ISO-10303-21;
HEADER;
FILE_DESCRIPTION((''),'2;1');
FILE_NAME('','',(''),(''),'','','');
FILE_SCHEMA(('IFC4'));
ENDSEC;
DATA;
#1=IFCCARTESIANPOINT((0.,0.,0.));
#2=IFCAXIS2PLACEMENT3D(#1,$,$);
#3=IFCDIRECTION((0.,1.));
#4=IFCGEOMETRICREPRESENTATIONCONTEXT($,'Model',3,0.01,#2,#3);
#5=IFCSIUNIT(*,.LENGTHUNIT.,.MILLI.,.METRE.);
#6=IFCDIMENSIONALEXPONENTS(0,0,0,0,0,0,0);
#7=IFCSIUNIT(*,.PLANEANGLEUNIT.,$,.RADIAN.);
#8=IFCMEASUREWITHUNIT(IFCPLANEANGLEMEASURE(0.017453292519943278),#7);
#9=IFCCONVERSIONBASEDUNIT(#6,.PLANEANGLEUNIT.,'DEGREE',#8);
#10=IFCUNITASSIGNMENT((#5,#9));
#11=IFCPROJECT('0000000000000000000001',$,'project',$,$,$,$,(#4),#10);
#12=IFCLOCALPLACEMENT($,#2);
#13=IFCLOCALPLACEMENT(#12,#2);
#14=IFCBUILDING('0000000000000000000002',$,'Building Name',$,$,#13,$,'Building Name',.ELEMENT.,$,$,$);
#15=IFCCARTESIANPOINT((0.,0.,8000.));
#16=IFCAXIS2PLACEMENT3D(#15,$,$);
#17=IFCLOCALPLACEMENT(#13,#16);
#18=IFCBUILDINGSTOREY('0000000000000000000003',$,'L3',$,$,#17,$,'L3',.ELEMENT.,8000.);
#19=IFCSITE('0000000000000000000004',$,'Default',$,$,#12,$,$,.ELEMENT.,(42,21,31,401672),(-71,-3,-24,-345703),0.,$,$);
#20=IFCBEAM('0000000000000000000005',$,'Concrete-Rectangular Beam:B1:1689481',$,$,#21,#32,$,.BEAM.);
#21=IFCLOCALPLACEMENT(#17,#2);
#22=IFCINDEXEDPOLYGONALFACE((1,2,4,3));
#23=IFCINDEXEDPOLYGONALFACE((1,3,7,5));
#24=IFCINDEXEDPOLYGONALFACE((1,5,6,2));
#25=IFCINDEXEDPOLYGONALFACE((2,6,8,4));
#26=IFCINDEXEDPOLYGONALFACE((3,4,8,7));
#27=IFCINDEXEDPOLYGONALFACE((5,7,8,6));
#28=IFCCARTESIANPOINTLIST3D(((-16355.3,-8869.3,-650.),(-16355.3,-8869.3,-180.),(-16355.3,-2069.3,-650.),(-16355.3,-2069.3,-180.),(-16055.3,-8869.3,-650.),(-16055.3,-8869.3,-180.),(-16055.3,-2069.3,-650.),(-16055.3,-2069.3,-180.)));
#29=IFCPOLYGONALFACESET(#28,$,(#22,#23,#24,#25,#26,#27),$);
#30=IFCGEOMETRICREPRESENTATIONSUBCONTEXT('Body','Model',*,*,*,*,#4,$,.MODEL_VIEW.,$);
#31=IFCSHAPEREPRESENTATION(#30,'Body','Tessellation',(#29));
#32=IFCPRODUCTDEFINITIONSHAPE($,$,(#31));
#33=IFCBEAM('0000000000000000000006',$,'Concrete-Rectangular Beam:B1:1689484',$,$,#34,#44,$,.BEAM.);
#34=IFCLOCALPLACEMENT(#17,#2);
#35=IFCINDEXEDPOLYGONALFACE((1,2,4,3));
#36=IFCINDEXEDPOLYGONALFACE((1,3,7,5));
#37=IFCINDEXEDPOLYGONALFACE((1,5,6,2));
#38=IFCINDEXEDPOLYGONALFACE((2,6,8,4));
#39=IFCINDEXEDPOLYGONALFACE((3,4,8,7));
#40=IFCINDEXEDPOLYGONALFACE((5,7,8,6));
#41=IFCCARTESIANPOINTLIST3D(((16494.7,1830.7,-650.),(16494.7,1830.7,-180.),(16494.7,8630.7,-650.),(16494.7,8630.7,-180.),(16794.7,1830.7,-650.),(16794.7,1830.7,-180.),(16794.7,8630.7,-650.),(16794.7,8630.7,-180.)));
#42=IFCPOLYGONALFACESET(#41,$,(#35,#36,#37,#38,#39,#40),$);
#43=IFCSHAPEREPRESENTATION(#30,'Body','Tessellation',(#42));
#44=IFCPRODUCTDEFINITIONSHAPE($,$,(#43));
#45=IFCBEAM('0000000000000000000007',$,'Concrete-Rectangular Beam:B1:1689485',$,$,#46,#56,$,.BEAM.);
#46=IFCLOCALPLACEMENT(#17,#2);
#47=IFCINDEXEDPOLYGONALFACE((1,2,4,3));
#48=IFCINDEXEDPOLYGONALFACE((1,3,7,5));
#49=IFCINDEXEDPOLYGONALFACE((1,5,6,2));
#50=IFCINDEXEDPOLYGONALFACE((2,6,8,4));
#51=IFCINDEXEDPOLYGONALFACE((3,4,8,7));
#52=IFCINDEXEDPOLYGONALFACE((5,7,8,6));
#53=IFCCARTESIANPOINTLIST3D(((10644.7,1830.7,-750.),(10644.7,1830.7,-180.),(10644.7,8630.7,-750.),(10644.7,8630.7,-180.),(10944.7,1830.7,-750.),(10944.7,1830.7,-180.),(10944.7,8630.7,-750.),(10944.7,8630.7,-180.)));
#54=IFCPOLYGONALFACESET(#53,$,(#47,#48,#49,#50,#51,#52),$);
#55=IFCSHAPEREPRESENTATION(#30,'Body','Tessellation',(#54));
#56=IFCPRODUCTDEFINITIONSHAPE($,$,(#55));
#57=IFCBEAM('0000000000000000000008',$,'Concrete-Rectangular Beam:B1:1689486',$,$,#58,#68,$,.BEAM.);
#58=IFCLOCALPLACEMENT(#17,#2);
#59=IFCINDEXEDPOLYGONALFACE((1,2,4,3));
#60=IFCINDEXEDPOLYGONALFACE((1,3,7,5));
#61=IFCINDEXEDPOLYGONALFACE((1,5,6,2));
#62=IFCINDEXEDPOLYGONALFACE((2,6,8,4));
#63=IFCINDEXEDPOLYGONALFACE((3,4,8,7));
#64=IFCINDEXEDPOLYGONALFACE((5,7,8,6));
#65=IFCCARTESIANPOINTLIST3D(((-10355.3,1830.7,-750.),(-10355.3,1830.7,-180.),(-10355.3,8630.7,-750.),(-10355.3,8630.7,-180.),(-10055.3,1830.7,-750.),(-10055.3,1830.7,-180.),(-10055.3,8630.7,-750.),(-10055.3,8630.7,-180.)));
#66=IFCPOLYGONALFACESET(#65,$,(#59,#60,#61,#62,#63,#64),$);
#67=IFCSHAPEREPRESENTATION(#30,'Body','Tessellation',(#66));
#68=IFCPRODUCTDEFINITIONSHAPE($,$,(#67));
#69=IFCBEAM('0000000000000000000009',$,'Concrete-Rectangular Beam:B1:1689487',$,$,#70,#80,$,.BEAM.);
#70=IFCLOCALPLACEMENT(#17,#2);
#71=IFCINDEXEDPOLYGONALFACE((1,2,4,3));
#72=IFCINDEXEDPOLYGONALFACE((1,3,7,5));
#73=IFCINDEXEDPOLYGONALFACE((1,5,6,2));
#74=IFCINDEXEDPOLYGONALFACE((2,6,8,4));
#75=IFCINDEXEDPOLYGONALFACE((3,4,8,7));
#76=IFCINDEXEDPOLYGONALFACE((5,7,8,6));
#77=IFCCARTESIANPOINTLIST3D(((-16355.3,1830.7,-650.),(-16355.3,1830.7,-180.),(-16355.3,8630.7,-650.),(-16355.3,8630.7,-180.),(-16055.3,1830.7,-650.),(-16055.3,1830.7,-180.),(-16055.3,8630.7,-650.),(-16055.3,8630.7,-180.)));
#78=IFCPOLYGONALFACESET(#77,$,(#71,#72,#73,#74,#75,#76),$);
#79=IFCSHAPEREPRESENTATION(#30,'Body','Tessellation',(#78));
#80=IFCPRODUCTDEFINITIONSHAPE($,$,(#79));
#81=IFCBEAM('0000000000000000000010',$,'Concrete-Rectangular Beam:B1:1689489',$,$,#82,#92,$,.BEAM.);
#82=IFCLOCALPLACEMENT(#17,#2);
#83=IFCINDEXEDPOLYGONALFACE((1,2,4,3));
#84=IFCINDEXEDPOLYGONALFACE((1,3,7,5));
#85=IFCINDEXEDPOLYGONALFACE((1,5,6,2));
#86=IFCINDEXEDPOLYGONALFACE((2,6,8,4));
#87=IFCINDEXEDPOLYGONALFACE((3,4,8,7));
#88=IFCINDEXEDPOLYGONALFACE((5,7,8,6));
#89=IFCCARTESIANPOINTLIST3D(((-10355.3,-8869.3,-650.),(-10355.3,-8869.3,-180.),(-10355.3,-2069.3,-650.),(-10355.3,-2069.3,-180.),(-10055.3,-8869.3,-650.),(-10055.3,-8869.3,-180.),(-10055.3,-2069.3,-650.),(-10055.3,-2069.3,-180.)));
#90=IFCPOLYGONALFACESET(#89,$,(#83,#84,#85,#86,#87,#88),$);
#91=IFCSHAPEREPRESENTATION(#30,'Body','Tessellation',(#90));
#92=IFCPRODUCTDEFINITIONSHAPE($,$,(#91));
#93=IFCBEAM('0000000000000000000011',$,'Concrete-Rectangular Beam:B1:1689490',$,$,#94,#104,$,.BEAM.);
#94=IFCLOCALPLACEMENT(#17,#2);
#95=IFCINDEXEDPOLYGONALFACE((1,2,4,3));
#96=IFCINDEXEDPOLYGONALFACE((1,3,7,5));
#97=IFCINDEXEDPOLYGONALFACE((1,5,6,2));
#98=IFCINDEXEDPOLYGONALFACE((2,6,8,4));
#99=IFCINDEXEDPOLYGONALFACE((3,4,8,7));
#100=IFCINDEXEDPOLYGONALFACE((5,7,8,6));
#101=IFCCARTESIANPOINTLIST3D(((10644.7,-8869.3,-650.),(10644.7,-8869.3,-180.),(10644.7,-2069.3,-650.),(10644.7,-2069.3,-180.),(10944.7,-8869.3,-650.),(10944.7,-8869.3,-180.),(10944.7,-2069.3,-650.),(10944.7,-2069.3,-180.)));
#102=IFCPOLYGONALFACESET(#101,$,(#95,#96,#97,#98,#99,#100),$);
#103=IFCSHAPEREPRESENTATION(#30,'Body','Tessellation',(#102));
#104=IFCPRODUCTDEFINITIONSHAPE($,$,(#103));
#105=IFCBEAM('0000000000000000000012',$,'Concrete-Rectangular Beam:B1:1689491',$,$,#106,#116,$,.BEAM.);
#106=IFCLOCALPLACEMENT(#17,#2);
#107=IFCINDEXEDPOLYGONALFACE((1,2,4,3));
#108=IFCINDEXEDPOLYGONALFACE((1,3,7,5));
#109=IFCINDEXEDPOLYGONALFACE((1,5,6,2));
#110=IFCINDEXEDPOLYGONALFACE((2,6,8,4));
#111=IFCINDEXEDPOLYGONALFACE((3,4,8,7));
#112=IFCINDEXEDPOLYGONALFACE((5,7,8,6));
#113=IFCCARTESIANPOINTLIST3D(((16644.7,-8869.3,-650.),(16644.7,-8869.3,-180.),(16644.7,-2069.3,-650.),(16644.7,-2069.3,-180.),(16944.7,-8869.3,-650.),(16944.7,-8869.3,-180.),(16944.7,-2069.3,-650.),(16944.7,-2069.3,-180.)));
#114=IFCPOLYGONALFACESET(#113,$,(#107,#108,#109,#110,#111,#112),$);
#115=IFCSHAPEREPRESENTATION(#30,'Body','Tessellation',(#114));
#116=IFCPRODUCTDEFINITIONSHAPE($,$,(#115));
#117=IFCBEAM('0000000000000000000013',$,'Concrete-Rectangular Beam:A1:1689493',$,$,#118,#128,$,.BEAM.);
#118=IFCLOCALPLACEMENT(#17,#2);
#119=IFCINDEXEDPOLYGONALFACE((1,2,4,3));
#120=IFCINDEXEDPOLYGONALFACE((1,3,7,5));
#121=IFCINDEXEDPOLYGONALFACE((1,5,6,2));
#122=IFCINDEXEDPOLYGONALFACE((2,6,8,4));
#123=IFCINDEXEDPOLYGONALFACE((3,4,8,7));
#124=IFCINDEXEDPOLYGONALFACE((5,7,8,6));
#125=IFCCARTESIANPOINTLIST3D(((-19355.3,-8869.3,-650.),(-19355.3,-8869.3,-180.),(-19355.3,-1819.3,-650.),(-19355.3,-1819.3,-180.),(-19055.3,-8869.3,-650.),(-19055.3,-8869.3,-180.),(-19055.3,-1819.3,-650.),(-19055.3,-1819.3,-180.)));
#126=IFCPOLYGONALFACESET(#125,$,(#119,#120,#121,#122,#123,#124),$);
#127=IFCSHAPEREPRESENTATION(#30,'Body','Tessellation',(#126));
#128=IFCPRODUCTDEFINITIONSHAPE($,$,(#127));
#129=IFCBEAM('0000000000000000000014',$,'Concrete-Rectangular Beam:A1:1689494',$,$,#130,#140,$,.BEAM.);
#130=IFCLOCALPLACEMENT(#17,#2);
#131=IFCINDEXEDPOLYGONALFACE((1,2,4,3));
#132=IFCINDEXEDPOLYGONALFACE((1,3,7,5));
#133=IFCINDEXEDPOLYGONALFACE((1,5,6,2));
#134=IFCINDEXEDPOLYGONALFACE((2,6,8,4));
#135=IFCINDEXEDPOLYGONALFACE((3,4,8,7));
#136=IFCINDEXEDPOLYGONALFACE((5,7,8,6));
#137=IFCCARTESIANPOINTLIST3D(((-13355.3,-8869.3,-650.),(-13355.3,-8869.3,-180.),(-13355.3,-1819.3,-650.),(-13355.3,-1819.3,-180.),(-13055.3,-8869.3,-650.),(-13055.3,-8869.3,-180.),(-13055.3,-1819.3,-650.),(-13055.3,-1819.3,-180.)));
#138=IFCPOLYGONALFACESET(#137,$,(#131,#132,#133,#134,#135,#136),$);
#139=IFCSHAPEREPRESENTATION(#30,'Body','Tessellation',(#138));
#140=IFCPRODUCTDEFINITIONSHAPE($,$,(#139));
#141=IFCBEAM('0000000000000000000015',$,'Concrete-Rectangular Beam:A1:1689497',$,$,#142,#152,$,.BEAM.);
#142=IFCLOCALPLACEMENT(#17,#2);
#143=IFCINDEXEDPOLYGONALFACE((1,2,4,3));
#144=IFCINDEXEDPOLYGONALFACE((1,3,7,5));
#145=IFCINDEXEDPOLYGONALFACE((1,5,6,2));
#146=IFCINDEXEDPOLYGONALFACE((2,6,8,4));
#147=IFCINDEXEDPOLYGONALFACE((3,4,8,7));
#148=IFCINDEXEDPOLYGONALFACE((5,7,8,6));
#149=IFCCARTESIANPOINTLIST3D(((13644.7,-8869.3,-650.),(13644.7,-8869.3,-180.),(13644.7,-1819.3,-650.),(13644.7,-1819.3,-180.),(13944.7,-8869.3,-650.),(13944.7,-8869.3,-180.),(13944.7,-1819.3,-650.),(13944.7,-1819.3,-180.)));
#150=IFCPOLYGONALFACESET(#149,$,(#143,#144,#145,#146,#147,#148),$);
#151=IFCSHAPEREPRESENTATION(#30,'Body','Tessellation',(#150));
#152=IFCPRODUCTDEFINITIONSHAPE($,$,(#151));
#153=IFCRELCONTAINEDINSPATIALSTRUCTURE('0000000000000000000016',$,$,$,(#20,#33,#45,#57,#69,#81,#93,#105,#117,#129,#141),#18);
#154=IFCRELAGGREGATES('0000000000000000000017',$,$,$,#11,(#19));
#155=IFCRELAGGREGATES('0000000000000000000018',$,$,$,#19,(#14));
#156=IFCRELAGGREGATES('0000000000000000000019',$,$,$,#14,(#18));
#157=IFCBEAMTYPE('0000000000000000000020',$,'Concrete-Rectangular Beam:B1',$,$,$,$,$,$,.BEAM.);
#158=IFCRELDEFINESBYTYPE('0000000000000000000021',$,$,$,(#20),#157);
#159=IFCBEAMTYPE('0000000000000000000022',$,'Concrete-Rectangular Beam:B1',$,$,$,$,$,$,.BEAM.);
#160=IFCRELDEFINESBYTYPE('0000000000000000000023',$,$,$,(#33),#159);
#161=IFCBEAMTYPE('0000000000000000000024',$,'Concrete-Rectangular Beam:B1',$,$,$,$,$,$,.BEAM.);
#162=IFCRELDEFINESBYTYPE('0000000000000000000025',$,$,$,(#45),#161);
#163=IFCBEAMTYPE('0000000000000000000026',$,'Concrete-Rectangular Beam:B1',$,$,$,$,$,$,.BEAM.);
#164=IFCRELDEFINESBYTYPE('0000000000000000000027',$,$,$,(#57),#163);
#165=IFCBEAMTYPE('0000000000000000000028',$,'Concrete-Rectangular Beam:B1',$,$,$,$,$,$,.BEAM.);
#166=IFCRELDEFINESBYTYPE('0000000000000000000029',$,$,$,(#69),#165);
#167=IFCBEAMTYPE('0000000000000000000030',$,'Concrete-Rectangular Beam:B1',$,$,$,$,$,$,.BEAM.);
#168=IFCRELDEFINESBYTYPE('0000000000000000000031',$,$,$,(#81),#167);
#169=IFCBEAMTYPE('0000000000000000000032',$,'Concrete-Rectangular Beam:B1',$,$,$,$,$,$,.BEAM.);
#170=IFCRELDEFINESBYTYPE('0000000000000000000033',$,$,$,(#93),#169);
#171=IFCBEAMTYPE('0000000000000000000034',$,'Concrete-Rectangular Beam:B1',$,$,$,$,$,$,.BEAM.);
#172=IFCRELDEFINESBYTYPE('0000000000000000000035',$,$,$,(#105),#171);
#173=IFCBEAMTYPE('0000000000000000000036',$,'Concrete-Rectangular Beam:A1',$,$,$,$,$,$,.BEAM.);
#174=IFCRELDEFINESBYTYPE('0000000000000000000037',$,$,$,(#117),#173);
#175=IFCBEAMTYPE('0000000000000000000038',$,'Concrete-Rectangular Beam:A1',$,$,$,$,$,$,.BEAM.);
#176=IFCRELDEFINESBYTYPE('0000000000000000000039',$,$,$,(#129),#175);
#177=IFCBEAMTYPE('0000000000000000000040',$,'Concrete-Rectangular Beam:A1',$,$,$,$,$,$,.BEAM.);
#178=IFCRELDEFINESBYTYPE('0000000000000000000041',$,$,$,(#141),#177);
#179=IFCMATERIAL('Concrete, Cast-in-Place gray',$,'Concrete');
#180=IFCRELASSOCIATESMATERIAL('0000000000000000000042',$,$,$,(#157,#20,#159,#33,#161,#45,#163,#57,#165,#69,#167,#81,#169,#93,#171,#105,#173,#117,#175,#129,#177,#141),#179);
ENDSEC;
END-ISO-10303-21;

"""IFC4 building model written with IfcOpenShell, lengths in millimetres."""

from ifc_helpers import new_model, entity, si_unit, converted_unit, direction, frame, origin, place, context, subcontext, project, spatial, indexed_curve, outline, extrude, source, transform, mapped, material, type_object, type_shapes, element, save


model = new_model("IFC4")

# Units and contexts
model_context = context("Model", 3, precision=0.01, world=origin(), true_north=direction((0.0, 1.0)))
body_context = subcontext(model_context, "Body", "Model", "MODEL_VIEW")
ifc_project = project(units=[si_unit("LENGTHUNIT", "METRE", prefix="MILLI"), converted_unit("PLANEANGLEUNIT", "DEGREE", entity("IfcPlaneAngleMeasure", 0.017453292519943278), si_unit("PLANEANGLEUNIT", "RADIAN"), dimensions=[0, 0, 0, 0, 0, 0, 0])], contexts=[model_context])

# Site, building, storey
site_placement = place(None, origin())
site = spatial("IfcSite", under=ifc_project, at=site_placement, Name="Default", CompositionType="ELEMENT", RefLatitude=(42, 21, 31, 401672), RefLongitude=(-71, -3, -24, -345703), RefElevation=0.0)
building_placement = place(site_placement, origin())
building = spatial("IfcBuilding", under=site, at=building_placement, Name="Building Name", LongName="Building Name", CompositionType="ELEMENT")
storey_placement = place(building_placement, frame((0.0, 0.0, 8000.0)))
storey = spatial("IfcBuildingStorey", under=building, at=storey_placement, Name="L3", LongName="L3", CompositionType="ELEMENT", Elevation=8000.0)

# Beams
ifc_material = material(Name="Concrete, Cast-in-Place gray", Category="Concrete")
beam_type_1 = type_object("IfcBeamType", Name="Concrete-Rectangular Beam:B1", PredefinedType="BEAM", material=ifc_material)
shared_shape_1 = source(origin(), body_context, "Body", "SweptSolid", [
    extrude(outline(indexed_curve([(-150.0, -235.0), (150.0, -235.0), (150.0, 235.0), (-150.0, 235.0), (-150.0, -235.0)], self_intersect=False)), frame((-16205.3, -2069.3, 7585.0), z_axis=(0.0, -1.0, 0.0), x_axis=(-1.0, 0.0, 0.0)), (0.0, 0.0, 1.0), 6800.0),
])
type_shapes(beam_type_1, [shared_shape_1])
beam_1_placement = place(storey_placement, frame((0.0, 0.0, -8000.0)))
element("IfcBeam", 1, at=beam_1_placement, inside=storey, type_object=beam_type_1, material=ifc_material, Name="Concrete-Rectangular Beam:B1:1689481", PredefinedType="BEAM", context=body_context, shape_type="MappedRepresentation", body=[
    mapped(shared_shape_1, transform((0.0, 0.0, 0.0), scale=1.0)),
])
beam_type_2 = type_object("IfcBeamType", Name="Concrete-Rectangular Beam:B1", PredefinedType="BEAM", material=ifc_material)
shared_shape_2 = source(origin(), body_context, "Body", "SweptSolid", [
    extrude(outline(indexed_curve([(-150.0, -235.0), (150.0, -235.0), (150.0, 235.0), (-150.0, 235.0), (-150.0, -235.0)], self_intersect=False)), frame((16644.7, 8630.7, 7585.0), z_axis=(0.0, -1.0, 0.0), x_axis=(-1.0, 0.0, 0.0)), (0.0, 0.0, 1.0), 6800.0),
])
type_shapes(beam_type_2, [shared_shape_2])
beam_2_placement = place(storey_placement, frame((0.0, 0.0, -8000.0)))
element("IfcBeam", 2, at=beam_2_placement, inside=storey, type_object=beam_type_2, material=ifc_material, Name="Concrete-Rectangular Beam:B1:1689484", PredefinedType="BEAM", context=body_context, shape_type="MappedRepresentation", body=[
    mapped(shared_shape_2, transform((0.0, 0.0, 0.0), scale=1.0)),
])
beam_type_3 = type_object("IfcBeamType", Name="Concrete-Rectangular Beam:B1", PredefinedType="BEAM", material=ifc_material)
shared_shape_3 = source(origin(), body_context, "Body", "SweptSolid", [
    extrude(outline(indexed_curve([(-150.0, -285.0), (150.0, -285.0), (150.0, 285.0), (-150.0, 285.0), (-150.0, -285.0)], self_intersect=False)), frame((10794.7, 8630.7, 7535.0), z_axis=(0.0, -1.0, 0.0), x_axis=(-1.0, 0.0, 0.0)), (0.0, 0.0, 1.0), 6800.0),
])
type_shapes(beam_type_3, [shared_shape_3])
beam_3_placement = place(storey_placement, frame((0.0, 0.0, -8000.0)))
element("IfcBeam", 3, at=beam_3_placement, inside=storey, type_object=beam_type_3, material=ifc_material, Name="Concrete-Rectangular Beam:B1:1689485", PredefinedType="BEAM", context=body_context, shape_type="MappedRepresentation", body=[
    mapped(shared_shape_3, transform((0.0, 0.0, 0.0), scale=1.0)),
])
beam_type_4 = type_object("IfcBeamType", Name="Concrete-Rectangular Beam:B1", PredefinedType="BEAM", material=ifc_material)
shared_shape_4 = source(origin(), body_context, "Body", "SweptSolid", [
    extrude(outline(indexed_curve([(-150.0, -285.0), (150.0, -285.0), (150.0, 285.0), (-150.0, 285.0), (-150.0, -285.0)], self_intersect=False)), frame((-10205.3, 8630.7, 7535.0), z_axis=(0.0, -1.0, 0.0), x_axis=(-1.0, 0.0, 0.0)), (0.0, 0.0, 1.0), 6800.0),
])
type_shapes(beam_type_4, [shared_shape_4])
beam_4_placement = place(storey_placement, frame((0.0, 0.0, -8000.0)))
element("IfcBeam", 4, at=beam_4_placement, inside=storey, type_object=beam_type_4, material=ifc_material, Name="Concrete-Rectangular Beam:B1:1689486", PredefinedType="BEAM", context=body_context, shape_type="MappedRepresentation", body=[
    mapped(shared_shape_4, transform((0.0, 0.0, 0.0), scale=1.0)),
])
beam_type_5 = type_object("IfcBeamType", Name="Concrete-Rectangular Beam:B1", PredefinedType="BEAM", material=ifc_material)
shared_shape_5 = source(origin(), body_context, "Body", "SweptSolid", [
    extrude(outline(indexed_curve([(-150.0, -235.0), (150.0, -235.0), (150.0, 235.0), (-150.0, 235.0), (-150.0, -235.0)], self_intersect=False)), frame((-16205.3, 8630.7, 7585.0), z_axis=(0.0, -1.0, 0.0), x_axis=(-1.0, 0.0, 0.0)), (0.0, 0.0, 1.0), 6800.0),
])
type_shapes(beam_type_5, [shared_shape_5])
beam_5_placement = place(storey_placement, frame((0.0, 0.0, -8000.0)))
element("IfcBeam", 5, at=beam_5_placement, inside=storey, type_object=beam_type_5, material=ifc_material, Name="Concrete-Rectangular Beam:B1:1689487", PredefinedType="BEAM", context=body_context, shape_type="MappedRepresentation", body=[
    mapped(shared_shape_5, transform((0.0, 0.0, 0.0), scale=1.0)),
])
beam_type_6 = type_object("IfcBeamType", Name="Concrete-Rectangular Beam:B1", PredefinedType="BEAM", material=ifc_material)
shared_shape_6 = source(origin(), body_context, "Body", "SweptSolid", [
    extrude(outline(indexed_curve([(-150.0, -235.0), (150.0, -235.0), (150.0, 235.0), (-150.0, 235.0), (-150.0, -235.0)], self_intersect=False)), frame((-10205.3, -8869.3, 7585.0), z_axis=(0.0, 1.0, 0.0), x_axis=(-1.0, 0.0, 0.0)), (0.0, 0.0, 1.0), 6800.0),
])
type_shapes(beam_type_6, [shared_shape_6])
beam_6_placement = place(storey_placement, frame((0.0, 0.0, -8000.0)))
element("IfcBeam", 6, at=beam_6_placement, inside=storey, type_object=beam_type_6, material=ifc_material, Name="Concrete-Rectangular Beam:B1:1689489", PredefinedType="BEAM", context=body_context, shape_type="MappedRepresentation", body=[
    mapped(shared_shape_6, transform((0.0, 0.0, 0.0), scale=1.0)),
])
beam_type_7 = type_object("IfcBeamType", Name="Concrete-Rectangular Beam:B1", PredefinedType="BEAM", material=ifc_material)
shared_shape_7 = source(origin(), body_context, "Body", "SweptSolid", [
    extrude(outline(indexed_curve([(-150.0, -235.0), (150.0, -235.0), (150.0, 235.0), (-150.0, 235.0), (-150.0, -235.0)], self_intersect=False)), frame((10794.7, -8869.3, 7585.0), z_axis=(0.0, 1.0, 0.0), x_axis=(-1.0, 0.0, 0.0)), (0.0, 0.0, 1.0), 6800.0),
])
type_shapes(beam_type_7, [shared_shape_7])
beam_7_placement = place(storey_placement, frame((0.0, 0.0, -8000.0)))
element("IfcBeam", 7, at=beam_7_placement, inside=storey, type_object=beam_type_7, material=ifc_material, Name="Concrete-Rectangular Beam:B1:1689490", PredefinedType="BEAM", context=body_context, shape_type="MappedRepresentation", body=[
    mapped(shared_shape_7, transform((0.0, 0.0, 0.0), scale=1.0)),
])
beam_type_8 = type_object("IfcBeamType", Name="Concrete-Rectangular Beam:B1", PredefinedType="BEAM", material=ifc_material)
shared_shape_8 = source(origin(), body_context, "Body", "SweptSolid", [
    extrude(outline(indexed_curve([(-150.0, -235.0), (150.0, -235.0), (150.0, 235.0), (-150.0, 235.0), (-150.0, -235.0)], self_intersect=False)), frame((16794.7, -8869.3, 7585.0), z_axis=(0.0, 1.0, 0.0), x_axis=(-1.0, 0.0, 0.0)), (0.0, 0.0, 1.0), 6800.0),
])
type_shapes(beam_type_8, [shared_shape_8])
beam_8_placement = place(storey_placement, frame((0.0, 0.0, -8000.0)))
element("IfcBeam", 8, at=beam_8_placement, inside=storey, type_object=beam_type_8, material=ifc_material, Name="Concrete-Rectangular Beam:B1:1689491", PredefinedType="BEAM", context=body_context, shape_type="MappedRepresentation", body=[
    mapped(shared_shape_8, transform((0.0, 0.0, 0.0), scale=1.0)),
])
beam_type_9 = type_object("IfcBeamType", Name="Concrete-Rectangular Beam:A1", PredefinedType="BEAM", material=ifc_material)
shared_shape_9 = source(origin(), body_context, "Body", "SweptSolid", [
    extrude(outline(indexed_curve([(-150.0, -235.0), (150.0, -235.0), (150.0, 235.0), (-150.0, 235.0), (-150.0, -235.0)], self_intersect=False)), frame((-19205.3, -8869.3, 7585.0), z_axis=(0.0, 1.0, 0.0), x_axis=(-1.0, 0.0, 0.0)), (0.0, 0.0, 1.0), 7050.0),
])
type_shapes(beam_type_9, [shared_shape_9])
beam_9_placement = place(storey_placement, frame((0.0, 0.0, -8000.0)))
element("IfcBeam", 9, at=beam_9_placement, inside=storey, type_object=beam_type_9, material=ifc_material, Name="Concrete-Rectangular Beam:A1:1689493", PredefinedType="BEAM", context=body_context, shape_type="MappedRepresentation", body=[
    mapped(shared_shape_9, transform((0.0, 0.0, 0.0), scale=1.0)),
])
beam_type_10 = type_object("IfcBeamType", Name="Concrete-Rectangular Beam:A1", PredefinedType="BEAM", material=ifc_material)
shared_shape_10 = source(origin(), body_context, "Body", "SweptSolid", [
    extrude(outline(indexed_curve([(-150.0, -235.0), (150.0, -235.0), (150.0, 235.0), (-150.0, 235.0), (-150.0, -235.0)], self_intersect=False)), frame((-13205.3, -8869.3, 7585.0), z_axis=(0.0, 1.0, 0.0), x_axis=(-1.0, 0.0, 0.0)), (0.0, 0.0, 1.0), 7050.0),
])
type_shapes(beam_type_10, [shared_shape_10])
beam_10_placement = place(storey_placement, frame((0.0, 0.0, -8000.0)))
element("IfcBeam", 10, at=beam_10_placement, inside=storey, type_object=beam_type_10, material=ifc_material, Name="Concrete-Rectangular Beam:A1:1689494", PredefinedType="BEAM", context=body_context, shape_type="MappedRepresentation", body=[
    mapped(shared_shape_10, transform((0.0, 0.0, 0.0), scale=1.0)),
])
beam_type_11 = type_object("IfcBeamType", Name="Concrete-Rectangular Beam:A1", PredefinedType="BEAM", material=ifc_material)
shared_shape_11 = source(origin(), body_context, "Body", "SweptSolid", [
    extrude(outline(indexed_curve([(-150.0, -235.0), (150.0, -235.0), (150.0, 235.0), (-150.0, 235.0), (-150.0, -235.0)], self_intersect=False)), frame((13794.7, -8869.3, 7585.0), z_axis=(0.0, 1.0, 0.0), x_axis=(-1.0, 0.0, 0.0)), (0.0, 0.0, 1.0), 7050.0),
])
type_shapes(beam_type_11, [shared_shape_11])
beam_11_placement = place(storey_placement, frame((0.0, 0.0, -8000.0)))
element("IfcBeam", 11, at=beam_11_placement, inside=storey, type_object=beam_type_11, material=ifc_material, Name="Concrete-Rectangular Beam:A1:1689497", PredefinedType="BEAM", context=body_context, shape_type="MappedRepresentation", body=[
    mapped(shared_shape_11, transform((0.0, 0.0, 0.0), scale=1.0)),
])

save(model, "model.ifc")
